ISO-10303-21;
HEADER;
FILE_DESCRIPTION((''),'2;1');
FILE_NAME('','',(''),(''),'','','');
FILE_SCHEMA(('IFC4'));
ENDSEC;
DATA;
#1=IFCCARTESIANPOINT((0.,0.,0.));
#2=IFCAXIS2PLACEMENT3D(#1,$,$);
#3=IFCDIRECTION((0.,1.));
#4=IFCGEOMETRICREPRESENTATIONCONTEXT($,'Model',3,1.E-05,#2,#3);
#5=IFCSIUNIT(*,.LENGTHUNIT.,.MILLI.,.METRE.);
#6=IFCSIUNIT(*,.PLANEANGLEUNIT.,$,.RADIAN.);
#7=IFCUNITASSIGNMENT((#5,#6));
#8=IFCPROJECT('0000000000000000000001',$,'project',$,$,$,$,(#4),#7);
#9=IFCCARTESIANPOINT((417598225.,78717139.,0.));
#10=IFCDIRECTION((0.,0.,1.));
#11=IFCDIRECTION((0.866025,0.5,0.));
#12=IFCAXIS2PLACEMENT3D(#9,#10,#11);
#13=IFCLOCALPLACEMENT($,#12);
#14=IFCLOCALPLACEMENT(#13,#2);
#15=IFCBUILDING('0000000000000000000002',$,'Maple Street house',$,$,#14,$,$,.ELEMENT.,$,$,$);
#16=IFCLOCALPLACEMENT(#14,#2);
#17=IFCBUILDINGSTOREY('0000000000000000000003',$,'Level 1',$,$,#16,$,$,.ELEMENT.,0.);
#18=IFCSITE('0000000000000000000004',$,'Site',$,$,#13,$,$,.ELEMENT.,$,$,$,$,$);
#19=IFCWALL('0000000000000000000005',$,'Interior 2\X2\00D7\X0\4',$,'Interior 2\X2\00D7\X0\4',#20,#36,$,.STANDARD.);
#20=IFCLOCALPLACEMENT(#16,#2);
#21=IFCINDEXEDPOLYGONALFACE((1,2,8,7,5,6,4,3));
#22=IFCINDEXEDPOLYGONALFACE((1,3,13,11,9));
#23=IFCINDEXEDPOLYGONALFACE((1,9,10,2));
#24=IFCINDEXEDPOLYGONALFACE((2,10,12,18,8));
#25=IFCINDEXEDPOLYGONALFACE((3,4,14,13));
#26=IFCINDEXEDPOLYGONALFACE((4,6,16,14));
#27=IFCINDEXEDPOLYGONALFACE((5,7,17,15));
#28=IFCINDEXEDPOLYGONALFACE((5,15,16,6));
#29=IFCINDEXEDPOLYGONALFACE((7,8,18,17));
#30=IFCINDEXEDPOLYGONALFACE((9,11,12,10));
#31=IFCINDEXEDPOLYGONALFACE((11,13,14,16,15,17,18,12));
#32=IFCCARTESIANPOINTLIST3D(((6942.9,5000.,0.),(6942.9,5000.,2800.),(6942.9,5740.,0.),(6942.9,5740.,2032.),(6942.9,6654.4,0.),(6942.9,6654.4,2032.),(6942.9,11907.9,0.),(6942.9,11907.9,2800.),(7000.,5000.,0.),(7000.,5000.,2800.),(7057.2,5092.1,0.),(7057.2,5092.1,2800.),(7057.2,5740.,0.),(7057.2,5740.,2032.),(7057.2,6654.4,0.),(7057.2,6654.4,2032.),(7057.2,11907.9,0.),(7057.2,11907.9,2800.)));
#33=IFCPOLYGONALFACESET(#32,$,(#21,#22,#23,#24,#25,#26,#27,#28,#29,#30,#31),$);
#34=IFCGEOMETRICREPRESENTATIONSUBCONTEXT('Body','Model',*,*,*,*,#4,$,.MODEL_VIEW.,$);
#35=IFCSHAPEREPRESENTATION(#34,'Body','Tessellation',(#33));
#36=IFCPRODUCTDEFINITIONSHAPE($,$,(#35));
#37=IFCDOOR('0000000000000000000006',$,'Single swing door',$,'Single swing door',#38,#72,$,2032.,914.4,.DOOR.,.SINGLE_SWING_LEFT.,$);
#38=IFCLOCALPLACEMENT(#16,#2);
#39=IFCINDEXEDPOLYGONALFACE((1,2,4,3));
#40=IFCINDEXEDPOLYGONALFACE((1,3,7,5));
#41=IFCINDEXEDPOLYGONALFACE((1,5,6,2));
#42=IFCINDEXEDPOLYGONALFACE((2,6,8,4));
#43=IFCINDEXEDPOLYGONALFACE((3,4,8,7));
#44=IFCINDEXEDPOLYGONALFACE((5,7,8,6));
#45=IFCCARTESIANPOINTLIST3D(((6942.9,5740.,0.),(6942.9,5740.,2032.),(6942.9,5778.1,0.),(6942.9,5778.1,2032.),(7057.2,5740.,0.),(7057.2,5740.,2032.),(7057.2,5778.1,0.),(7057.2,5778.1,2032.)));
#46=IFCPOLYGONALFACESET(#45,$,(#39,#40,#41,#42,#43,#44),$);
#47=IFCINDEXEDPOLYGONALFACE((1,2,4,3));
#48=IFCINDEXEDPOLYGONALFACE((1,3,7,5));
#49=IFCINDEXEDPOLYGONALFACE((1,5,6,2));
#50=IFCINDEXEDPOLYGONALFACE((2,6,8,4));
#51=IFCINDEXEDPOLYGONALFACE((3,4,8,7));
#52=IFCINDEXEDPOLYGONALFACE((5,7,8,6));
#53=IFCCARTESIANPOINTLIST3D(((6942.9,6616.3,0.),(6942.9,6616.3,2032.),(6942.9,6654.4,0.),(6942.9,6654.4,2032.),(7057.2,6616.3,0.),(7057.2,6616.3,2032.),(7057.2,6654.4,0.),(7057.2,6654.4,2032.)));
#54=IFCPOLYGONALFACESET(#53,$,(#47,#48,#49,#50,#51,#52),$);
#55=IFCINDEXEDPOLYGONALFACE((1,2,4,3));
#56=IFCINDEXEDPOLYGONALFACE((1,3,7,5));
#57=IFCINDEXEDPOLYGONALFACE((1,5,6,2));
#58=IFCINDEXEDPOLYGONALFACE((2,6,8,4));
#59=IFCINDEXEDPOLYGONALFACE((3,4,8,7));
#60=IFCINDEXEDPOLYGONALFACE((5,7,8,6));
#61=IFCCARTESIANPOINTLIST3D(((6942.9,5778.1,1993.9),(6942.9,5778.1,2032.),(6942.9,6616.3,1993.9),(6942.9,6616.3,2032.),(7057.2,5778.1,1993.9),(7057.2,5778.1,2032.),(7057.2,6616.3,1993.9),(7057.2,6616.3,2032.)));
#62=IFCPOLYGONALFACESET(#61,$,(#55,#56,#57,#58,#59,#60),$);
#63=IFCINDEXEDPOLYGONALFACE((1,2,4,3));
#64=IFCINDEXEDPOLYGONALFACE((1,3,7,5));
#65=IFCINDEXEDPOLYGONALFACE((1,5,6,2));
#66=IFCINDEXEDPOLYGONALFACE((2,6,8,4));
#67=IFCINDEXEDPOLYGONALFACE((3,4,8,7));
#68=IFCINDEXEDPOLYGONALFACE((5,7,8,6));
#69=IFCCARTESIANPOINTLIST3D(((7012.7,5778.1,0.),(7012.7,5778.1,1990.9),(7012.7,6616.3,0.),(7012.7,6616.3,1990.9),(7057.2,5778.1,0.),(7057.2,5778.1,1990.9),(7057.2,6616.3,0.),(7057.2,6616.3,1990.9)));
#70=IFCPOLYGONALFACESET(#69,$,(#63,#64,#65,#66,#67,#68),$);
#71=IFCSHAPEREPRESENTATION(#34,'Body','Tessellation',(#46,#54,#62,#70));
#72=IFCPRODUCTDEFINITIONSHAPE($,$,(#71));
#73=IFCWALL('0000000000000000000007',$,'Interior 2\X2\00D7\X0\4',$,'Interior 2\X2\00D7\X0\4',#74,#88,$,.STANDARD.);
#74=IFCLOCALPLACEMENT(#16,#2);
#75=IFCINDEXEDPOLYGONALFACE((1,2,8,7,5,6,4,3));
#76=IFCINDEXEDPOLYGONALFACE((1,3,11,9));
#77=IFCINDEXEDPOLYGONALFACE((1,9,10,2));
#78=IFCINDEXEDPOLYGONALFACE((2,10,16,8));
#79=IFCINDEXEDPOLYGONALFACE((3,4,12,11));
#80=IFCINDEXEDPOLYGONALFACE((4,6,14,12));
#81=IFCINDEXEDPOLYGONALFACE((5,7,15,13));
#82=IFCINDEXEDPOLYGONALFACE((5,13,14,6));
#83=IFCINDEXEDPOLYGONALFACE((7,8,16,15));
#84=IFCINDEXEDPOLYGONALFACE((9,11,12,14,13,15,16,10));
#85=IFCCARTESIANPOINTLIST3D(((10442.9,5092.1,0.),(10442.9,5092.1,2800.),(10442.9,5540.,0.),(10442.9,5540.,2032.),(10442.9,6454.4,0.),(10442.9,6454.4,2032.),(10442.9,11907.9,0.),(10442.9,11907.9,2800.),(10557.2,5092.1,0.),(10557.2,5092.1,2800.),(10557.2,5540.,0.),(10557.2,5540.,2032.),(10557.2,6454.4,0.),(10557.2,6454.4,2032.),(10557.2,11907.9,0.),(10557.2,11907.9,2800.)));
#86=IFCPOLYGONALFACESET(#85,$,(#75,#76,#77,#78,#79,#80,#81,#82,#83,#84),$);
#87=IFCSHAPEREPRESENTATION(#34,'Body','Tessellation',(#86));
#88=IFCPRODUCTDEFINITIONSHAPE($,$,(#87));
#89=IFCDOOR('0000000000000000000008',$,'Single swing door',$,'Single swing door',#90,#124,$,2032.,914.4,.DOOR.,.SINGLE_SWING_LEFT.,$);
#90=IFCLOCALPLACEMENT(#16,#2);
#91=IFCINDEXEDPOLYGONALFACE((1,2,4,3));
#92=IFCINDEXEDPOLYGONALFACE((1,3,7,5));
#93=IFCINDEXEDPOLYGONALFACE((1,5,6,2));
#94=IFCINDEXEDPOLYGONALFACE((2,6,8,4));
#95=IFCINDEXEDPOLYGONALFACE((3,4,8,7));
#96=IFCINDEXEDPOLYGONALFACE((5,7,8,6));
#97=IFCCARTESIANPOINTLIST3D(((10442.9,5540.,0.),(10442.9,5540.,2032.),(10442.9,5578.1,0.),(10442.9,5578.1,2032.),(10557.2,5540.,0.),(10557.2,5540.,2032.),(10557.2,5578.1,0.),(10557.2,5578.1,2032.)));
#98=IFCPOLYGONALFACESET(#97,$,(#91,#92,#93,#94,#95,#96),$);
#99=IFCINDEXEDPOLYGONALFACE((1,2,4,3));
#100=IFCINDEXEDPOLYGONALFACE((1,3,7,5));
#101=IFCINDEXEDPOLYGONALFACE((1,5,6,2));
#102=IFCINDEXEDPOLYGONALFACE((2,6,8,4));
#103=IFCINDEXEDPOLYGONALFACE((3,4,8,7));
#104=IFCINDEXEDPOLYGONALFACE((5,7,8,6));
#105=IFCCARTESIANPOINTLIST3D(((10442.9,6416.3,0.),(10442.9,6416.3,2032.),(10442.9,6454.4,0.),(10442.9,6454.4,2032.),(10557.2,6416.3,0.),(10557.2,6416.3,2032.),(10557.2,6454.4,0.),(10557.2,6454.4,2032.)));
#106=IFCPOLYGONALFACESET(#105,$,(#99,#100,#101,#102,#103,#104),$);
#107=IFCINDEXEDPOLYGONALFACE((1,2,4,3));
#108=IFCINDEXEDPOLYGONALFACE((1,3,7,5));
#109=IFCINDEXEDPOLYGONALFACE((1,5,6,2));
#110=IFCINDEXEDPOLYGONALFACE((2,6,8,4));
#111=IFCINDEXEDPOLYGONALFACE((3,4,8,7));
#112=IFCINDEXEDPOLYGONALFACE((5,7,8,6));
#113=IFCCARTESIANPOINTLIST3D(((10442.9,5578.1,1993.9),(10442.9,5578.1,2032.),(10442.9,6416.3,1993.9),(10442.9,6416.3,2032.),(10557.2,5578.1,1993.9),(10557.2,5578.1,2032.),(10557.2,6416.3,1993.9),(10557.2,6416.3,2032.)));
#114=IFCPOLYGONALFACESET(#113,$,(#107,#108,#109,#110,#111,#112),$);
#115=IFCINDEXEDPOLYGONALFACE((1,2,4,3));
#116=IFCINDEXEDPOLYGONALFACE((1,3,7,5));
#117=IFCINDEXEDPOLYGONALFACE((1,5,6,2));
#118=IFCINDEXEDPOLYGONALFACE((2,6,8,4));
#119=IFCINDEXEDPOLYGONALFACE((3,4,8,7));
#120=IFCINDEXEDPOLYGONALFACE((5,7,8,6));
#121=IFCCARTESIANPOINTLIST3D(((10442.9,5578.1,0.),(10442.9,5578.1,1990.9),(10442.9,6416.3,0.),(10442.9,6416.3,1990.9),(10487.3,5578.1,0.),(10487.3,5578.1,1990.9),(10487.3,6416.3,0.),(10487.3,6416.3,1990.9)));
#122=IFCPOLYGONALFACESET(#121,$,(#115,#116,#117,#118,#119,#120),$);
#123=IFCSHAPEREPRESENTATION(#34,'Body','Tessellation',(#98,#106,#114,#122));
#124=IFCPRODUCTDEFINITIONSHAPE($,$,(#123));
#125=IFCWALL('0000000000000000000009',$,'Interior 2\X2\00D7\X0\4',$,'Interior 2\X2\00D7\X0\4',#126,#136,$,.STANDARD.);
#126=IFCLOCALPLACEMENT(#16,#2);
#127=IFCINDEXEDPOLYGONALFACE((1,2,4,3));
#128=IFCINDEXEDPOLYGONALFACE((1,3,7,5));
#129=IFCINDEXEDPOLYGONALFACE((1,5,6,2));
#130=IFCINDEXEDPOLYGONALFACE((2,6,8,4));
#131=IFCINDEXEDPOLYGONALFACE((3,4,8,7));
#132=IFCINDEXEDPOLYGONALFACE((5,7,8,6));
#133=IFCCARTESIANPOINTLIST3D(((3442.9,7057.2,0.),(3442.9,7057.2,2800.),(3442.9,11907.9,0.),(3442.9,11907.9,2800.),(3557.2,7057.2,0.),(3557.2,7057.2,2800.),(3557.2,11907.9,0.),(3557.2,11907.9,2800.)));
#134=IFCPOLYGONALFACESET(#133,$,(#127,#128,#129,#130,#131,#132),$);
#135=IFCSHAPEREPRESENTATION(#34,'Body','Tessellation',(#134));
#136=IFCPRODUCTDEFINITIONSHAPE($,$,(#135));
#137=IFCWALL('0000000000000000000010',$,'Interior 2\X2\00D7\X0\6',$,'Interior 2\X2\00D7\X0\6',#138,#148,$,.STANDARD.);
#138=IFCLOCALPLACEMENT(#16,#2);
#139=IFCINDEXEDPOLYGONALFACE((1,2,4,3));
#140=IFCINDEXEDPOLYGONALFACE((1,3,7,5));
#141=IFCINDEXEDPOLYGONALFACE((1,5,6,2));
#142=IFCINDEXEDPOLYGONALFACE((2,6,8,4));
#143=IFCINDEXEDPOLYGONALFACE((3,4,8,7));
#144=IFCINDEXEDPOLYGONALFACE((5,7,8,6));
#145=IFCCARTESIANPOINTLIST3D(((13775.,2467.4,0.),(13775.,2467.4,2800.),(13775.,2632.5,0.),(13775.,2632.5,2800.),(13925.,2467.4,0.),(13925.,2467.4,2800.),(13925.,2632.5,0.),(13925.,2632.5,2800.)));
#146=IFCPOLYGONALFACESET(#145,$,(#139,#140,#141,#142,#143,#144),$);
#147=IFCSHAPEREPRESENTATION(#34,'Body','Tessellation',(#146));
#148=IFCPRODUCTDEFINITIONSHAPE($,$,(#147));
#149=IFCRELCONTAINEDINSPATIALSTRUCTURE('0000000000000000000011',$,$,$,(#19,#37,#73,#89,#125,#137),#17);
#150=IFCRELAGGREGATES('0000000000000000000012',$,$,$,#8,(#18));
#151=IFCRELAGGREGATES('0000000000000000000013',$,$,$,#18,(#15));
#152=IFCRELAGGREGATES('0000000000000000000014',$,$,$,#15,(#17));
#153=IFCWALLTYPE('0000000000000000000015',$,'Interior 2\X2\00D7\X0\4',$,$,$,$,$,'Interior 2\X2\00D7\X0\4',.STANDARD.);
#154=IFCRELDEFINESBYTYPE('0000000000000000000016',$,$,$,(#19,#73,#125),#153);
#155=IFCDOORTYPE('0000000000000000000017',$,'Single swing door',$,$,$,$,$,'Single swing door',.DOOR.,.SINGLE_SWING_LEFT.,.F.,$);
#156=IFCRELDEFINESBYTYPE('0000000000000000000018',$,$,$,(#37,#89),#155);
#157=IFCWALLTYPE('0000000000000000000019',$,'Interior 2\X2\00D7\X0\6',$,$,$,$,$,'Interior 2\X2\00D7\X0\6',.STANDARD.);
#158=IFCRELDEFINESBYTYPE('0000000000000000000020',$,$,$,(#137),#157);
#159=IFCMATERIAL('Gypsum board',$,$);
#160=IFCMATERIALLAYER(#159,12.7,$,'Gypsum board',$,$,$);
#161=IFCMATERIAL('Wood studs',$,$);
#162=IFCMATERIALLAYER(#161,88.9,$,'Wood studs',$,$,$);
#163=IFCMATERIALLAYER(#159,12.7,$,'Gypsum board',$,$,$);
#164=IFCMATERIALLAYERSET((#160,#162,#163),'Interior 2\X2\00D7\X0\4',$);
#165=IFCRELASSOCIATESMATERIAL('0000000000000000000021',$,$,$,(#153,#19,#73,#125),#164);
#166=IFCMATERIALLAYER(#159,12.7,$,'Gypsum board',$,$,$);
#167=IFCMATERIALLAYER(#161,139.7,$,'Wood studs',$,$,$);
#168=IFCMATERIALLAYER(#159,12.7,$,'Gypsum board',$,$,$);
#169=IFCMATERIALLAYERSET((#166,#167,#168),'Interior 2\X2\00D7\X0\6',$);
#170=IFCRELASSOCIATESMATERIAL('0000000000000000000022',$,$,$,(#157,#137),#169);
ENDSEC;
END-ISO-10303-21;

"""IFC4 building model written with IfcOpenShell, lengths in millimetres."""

from ifc_helpers import new_model, si_unit, direction, frame, origin, origin_with_axes, place, context, subcontext, project, spatial, polyline, outline, extrude, material, layer, layer_set, layer_usage, type_object, element, fill, save


model = new_model("IFC4")

# Units and contexts
model_context = context("Model", 3, precision=1e-05, world=origin(), true_north=direction((0.0, 1.0)))
body_context = subcontext(model_context, "Body", "Model", "MODEL_VIEW")
ifc_project = project(units=[si_unit("LENGTHUNIT", "METRE", prefix="MILLI"), si_unit("PLANEANGLEUNIT", "RADIAN")], contexts=[model_context])

# Site, building, storey
site_placement = place(None, frame((417598225.0, 78717139.0, 0.0), z_axis=(0.0, 0.0, 1.0), x_axis=(0.866025, 0.5, 0.0)))
site = spatial("IfcSite", under=ifc_project, at=site_placement, Name="Site", CompositionType="ELEMENT")
building_placement = place(site_placement, origin())
building = spatial("IfcBuilding", under=site, at=building_placement, Name="Maple Street house", CompositionType="ELEMENT")
storey_placement = place(building_placement, origin())
storey = spatial("IfcBuildingStorey", under=building, at=storey_placement, Name="Level 1", CompositionType="ELEMENT", Elevation=0.0)

# Shared definitions
ifc_material_1 = material(Name="Wood studs")
ifc_material_2 = material(Name="Gypsum board")

# Walls, openings, doors
ifc_layer_1 = layer(ifc_material_2, 12.7, Name="Gypsum board")
ifc_layer_2 = layer(ifc_material_1, 88.9, Name="Wood studs")
ifc_layer_3 = layer(ifc_material_2, 12.7, Name="Gypsum board")
ifc_layer_set_1 = layer_set([ifc_layer_1, ifc_layer_2, ifc_layer_3], Name="Interior 2×4")
ifc_layer_usage_1 = layer_usage(ifc_layer_set_1, "AXIS2", "NEGATIVE", 57.1)
wall_type_1 = type_object("IfcWallType", Name="Interior 2×4", ElementType="Interior 2×4", PredefinedType="STANDARD", material=ifc_layer_set_1)
wall_1_placement = place(storey_placement, frame((7000.0, 5000.0, 0.0), z_axis=(0.0, 0.0, 1.0), x_axis=(0.0, 1.0, 0.0)))
wall_1 = element("IfcWall", 1, at=wall_1_placement, inside=storey, type_object=wall_type_1, material=ifc_layer_usage_1, Name="Interior 2×4", ObjectType="Interior 2×4", PredefinedType="STANDARD", context=body_context, shape_type="SweptSolid", body=[
    extrude(outline(polyline([(92.1, -57.1), (6907.9, -57.1), (6907.9, 57.1), (0.0, 57.1), (0.0, 0.0), (92.1, -57.1)])), origin(), (0.0, 0.0, 1.0), 2800.0),
])
opening_1_placement = place(wall_1_placement, frame((740.0, 0.0, 0.0), z_axis=(0.0, 0.0, 1.0), x_axis=(1.0, 0.0, 0.0)))
opening_1 = element("IfcOpeningElement", 2, at=opening_1_placement, cuts=wall_1, PredefinedType="OPENING", context=body_context, shape_type="SweptSolid", body=[
    extrude(outline(polyline([(0.0, -67.2), (914.4, -67.2), (914.4, 67.2), (0.0, 67.2), (0.0, -67.2)])), origin(), (0.0, 0.0, 1.0), 2032.0),
])
door_type_1 = type_object("IfcDoorType", Name="Single swing door", ElementType="Single swing door", OperationType="SINGLE_SWING_LEFT", ParameterTakesPrecedence=False, PredefinedType="DOOR")
door_1_placement = place(opening_1_placement, origin_with_axes())
door_1 = element("IfcDoor", 3, at=door_1_placement, inside=storey, type_object=door_type_1, Name="Single swing door", ObjectType="Single swing door", OperationType="SINGLE_SWING_LEFT", OverallHeight=2032.0, OverallWidth=914.4, PredefinedType="DOOR", context=body_context, shape_type="SweptSolid", body=[
    extrude(outline(polyline([(0.0, -57.1), (38.1, -57.1), (38.1, 57.1), (0.0, 57.1), (0.0, -57.1)])), origin(), (0.0, 0.0, 1.0), 2032.0),
    extrude(outline(polyline([(876.3, -57.1), (914.4, -57.1), (914.4, 57.1), (876.3, 57.1), (876.3, -57.1)])), origin(), (0.0, 0.0, 1.0), 2032.0),
    extrude(outline(polyline([(38.1, -57.1), (876.3, -57.1), (876.3, 57.1), (38.1, 57.1), (38.1, -57.1)])), frame((0.0, 0.0, 1993.9)), (0.0, 0.0, 1.0), 38.1),
    extrude(outline(polyline([(38.1, -57.1), (876.3, -57.1), (876.3, -12.7), (38.1, -12.7), (38.1, -57.1)])), origin(), (0.0, 0.0, 1.0), 1990.9),
])
fill(opening_1, door_1)
ifc_layer_usage_2 = layer_usage(ifc_layer_set_1, "AXIS2", "NEGATIVE", 57.1)
wall_2_placement = place(storey_placement, frame((10500.0, 5000.0, 0.0), z_axis=(0.0, 0.0, 1.0), x_axis=(0.0, 1.0, 0.0)))
wall_2 = element("IfcWall", 4, at=wall_2_placement, inside=storey, type_object=wall_type_1, material=ifc_layer_usage_2, Name="Interior 2×4", ObjectType="Interior 2×4", PredefinedType="STANDARD", context=body_context, shape_type="SweptSolid", body=[
    extrude(outline(polyline([(92.1, -57.1), (6907.9, -57.1), (6907.9, 57.1), (92.1, 57.1), (92.1, -57.1)])), origin(), (0.0, 0.0, 1.0), 2800.0),
])
opening_2_placement = place(wall_2_placement, frame((540.0, 0.0, 0.0), z_axis=(0.0, 0.0, 1.0), x_axis=(1.0, 0.0, 0.0)))
opening_2 = element("IfcOpeningElement", 5, at=opening_2_placement, cuts=wall_2, PredefinedType="OPENING", context=body_context, shape_type="SweptSolid", body=[
    extrude(outline(polyline([(0.0, -67.2), (914.4, -67.2), (914.4, 67.2), (0.0, 67.2), (0.0, -67.2)])), origin(), (0.0, 0.0, 1.0), 2032.0),
])
door_2_placement = place(opening_2_placement, origin_with_axes())
door_2 = element("IfcDoor", 6, at=door_2_placement, inside=storey, type_object=door_type_1, Name="Single swing door", ObjectType="Single swing door", OperationType="SINGLE_SWING_LEFT", OverallHeight=2032.0, OverallWidth=914.4, PredefinedType="DOOR", context=body_context, shape_type="SweptSolid", body=[
    extrude(outline(polyline([(0.0, -57.1), (38.1, -57.1), (38.1, 57.1), (0.0, 57.1), (0.0, -57.1)])), origin(), (0.0, 0.0, 1.0), 2032.0),
    extrude(outline(polyline([(876.3, -57.1), (914.4, -57.1), (914.4, 57.1), (876.3, 57.1), (876.3, -57.1)])), origin(), (0.0, 0.0, 1.0), 2032.0),
    extrude(outline(polyline([(38.1, -57.1), (876.3, -57.1), (876.3, 57.1), (38.1, 57.1), (38.1, -57.1)])), frame((0.0, 0.0, 1993.9)), (0.0, 0.0, 1.0), 38.1),
    extrude(outline(polyline([(38.1, 12.7), (876.3, 12.7), (876.3, 57.1), (38.1, 57.1), (38.1, 12.7)])), origin(), (0.0, 0.0, 1.0), 1990.9),
])
fill(opening_2, door_2)

# Walls
ifc_layer_usage_3 = layer_usage(ifc_layer_set_1, "AXIS2", "NEGATIVE", 57.1)
wall_3_placement = place(storey_placement, frame((3500.0, 7000.0, 0.0), z_axis=(0.0, 0.0, 1.0), x_axis=(0.0, 1.0, 0.0)))
element("IfcWall", 7, at=wall_3_placement, inside=storey, type_object=wall_type_1, material=ifc_layer_usage_3, Name="Interior 2×4", ObjectType="Interior 2×4", PredefinedType="STANDARD", context=body_context, shape_type="SweptSolid", body=[
    extrude(outline(polyline([(57.1, -57.1), (4907.9, -57.1), (4907.9, 57.1), (57.1, 57.1), (57.1, -57.1)])), origin(), (0.0, 0.0, 1.0), 2800.0),
])
ifc_layer_4 = layer(ifc_material_2, 12.7, Name="Gypsum board")
ifc_layer_5 = layer(ifc_material_1, 139.7, Name="Wood studs")
ifc_layer_6 = layer(ifc_material_2, 12.7, Name="Gypsum board")
ifc_layer_set_2 = layer_set([ifc_layer_4, ifc_layer_5, ifc_layer_6], Name="Interior 2×6")
ifc_layer_usage_4 = layer_usage(ifc_layer_set_2, "AXIS2", "NEGATIVE", 82.5)
wall_type_2 = type_object("IfcWallType", Name="Interior 2×6", ElementType="Interior 2×6", PredefinedType="STANDARD", material=ifc_layer_set_2)
wall_4_placement = place(storey_placement, frame((13775.0, 2550.0, 0.0), z_axis=(0.0, 0.0, 1.0), x_axis=(1.0, 0.0, 0.0)))
element("IfcWall", 8, at=wall_4_placement, inside=storey, type_object=wall_type_2, material=ifc_layer_usage_4, Name="Interior 2×6", ObjectType="Interior 2×6", PredefinedType="STANDARD", context=body_context, shape_type="SweptSolid", body=[
    extrude(outline(polyline([(0.0, -82.5), (150.0, -82.5), (150.0, 82.5), (0.0, 82.5), (0.0, -82.5)])), origin(), (0.0, 0.0, 1.0), 2800.0),
])

save(model, "model.ifc")
